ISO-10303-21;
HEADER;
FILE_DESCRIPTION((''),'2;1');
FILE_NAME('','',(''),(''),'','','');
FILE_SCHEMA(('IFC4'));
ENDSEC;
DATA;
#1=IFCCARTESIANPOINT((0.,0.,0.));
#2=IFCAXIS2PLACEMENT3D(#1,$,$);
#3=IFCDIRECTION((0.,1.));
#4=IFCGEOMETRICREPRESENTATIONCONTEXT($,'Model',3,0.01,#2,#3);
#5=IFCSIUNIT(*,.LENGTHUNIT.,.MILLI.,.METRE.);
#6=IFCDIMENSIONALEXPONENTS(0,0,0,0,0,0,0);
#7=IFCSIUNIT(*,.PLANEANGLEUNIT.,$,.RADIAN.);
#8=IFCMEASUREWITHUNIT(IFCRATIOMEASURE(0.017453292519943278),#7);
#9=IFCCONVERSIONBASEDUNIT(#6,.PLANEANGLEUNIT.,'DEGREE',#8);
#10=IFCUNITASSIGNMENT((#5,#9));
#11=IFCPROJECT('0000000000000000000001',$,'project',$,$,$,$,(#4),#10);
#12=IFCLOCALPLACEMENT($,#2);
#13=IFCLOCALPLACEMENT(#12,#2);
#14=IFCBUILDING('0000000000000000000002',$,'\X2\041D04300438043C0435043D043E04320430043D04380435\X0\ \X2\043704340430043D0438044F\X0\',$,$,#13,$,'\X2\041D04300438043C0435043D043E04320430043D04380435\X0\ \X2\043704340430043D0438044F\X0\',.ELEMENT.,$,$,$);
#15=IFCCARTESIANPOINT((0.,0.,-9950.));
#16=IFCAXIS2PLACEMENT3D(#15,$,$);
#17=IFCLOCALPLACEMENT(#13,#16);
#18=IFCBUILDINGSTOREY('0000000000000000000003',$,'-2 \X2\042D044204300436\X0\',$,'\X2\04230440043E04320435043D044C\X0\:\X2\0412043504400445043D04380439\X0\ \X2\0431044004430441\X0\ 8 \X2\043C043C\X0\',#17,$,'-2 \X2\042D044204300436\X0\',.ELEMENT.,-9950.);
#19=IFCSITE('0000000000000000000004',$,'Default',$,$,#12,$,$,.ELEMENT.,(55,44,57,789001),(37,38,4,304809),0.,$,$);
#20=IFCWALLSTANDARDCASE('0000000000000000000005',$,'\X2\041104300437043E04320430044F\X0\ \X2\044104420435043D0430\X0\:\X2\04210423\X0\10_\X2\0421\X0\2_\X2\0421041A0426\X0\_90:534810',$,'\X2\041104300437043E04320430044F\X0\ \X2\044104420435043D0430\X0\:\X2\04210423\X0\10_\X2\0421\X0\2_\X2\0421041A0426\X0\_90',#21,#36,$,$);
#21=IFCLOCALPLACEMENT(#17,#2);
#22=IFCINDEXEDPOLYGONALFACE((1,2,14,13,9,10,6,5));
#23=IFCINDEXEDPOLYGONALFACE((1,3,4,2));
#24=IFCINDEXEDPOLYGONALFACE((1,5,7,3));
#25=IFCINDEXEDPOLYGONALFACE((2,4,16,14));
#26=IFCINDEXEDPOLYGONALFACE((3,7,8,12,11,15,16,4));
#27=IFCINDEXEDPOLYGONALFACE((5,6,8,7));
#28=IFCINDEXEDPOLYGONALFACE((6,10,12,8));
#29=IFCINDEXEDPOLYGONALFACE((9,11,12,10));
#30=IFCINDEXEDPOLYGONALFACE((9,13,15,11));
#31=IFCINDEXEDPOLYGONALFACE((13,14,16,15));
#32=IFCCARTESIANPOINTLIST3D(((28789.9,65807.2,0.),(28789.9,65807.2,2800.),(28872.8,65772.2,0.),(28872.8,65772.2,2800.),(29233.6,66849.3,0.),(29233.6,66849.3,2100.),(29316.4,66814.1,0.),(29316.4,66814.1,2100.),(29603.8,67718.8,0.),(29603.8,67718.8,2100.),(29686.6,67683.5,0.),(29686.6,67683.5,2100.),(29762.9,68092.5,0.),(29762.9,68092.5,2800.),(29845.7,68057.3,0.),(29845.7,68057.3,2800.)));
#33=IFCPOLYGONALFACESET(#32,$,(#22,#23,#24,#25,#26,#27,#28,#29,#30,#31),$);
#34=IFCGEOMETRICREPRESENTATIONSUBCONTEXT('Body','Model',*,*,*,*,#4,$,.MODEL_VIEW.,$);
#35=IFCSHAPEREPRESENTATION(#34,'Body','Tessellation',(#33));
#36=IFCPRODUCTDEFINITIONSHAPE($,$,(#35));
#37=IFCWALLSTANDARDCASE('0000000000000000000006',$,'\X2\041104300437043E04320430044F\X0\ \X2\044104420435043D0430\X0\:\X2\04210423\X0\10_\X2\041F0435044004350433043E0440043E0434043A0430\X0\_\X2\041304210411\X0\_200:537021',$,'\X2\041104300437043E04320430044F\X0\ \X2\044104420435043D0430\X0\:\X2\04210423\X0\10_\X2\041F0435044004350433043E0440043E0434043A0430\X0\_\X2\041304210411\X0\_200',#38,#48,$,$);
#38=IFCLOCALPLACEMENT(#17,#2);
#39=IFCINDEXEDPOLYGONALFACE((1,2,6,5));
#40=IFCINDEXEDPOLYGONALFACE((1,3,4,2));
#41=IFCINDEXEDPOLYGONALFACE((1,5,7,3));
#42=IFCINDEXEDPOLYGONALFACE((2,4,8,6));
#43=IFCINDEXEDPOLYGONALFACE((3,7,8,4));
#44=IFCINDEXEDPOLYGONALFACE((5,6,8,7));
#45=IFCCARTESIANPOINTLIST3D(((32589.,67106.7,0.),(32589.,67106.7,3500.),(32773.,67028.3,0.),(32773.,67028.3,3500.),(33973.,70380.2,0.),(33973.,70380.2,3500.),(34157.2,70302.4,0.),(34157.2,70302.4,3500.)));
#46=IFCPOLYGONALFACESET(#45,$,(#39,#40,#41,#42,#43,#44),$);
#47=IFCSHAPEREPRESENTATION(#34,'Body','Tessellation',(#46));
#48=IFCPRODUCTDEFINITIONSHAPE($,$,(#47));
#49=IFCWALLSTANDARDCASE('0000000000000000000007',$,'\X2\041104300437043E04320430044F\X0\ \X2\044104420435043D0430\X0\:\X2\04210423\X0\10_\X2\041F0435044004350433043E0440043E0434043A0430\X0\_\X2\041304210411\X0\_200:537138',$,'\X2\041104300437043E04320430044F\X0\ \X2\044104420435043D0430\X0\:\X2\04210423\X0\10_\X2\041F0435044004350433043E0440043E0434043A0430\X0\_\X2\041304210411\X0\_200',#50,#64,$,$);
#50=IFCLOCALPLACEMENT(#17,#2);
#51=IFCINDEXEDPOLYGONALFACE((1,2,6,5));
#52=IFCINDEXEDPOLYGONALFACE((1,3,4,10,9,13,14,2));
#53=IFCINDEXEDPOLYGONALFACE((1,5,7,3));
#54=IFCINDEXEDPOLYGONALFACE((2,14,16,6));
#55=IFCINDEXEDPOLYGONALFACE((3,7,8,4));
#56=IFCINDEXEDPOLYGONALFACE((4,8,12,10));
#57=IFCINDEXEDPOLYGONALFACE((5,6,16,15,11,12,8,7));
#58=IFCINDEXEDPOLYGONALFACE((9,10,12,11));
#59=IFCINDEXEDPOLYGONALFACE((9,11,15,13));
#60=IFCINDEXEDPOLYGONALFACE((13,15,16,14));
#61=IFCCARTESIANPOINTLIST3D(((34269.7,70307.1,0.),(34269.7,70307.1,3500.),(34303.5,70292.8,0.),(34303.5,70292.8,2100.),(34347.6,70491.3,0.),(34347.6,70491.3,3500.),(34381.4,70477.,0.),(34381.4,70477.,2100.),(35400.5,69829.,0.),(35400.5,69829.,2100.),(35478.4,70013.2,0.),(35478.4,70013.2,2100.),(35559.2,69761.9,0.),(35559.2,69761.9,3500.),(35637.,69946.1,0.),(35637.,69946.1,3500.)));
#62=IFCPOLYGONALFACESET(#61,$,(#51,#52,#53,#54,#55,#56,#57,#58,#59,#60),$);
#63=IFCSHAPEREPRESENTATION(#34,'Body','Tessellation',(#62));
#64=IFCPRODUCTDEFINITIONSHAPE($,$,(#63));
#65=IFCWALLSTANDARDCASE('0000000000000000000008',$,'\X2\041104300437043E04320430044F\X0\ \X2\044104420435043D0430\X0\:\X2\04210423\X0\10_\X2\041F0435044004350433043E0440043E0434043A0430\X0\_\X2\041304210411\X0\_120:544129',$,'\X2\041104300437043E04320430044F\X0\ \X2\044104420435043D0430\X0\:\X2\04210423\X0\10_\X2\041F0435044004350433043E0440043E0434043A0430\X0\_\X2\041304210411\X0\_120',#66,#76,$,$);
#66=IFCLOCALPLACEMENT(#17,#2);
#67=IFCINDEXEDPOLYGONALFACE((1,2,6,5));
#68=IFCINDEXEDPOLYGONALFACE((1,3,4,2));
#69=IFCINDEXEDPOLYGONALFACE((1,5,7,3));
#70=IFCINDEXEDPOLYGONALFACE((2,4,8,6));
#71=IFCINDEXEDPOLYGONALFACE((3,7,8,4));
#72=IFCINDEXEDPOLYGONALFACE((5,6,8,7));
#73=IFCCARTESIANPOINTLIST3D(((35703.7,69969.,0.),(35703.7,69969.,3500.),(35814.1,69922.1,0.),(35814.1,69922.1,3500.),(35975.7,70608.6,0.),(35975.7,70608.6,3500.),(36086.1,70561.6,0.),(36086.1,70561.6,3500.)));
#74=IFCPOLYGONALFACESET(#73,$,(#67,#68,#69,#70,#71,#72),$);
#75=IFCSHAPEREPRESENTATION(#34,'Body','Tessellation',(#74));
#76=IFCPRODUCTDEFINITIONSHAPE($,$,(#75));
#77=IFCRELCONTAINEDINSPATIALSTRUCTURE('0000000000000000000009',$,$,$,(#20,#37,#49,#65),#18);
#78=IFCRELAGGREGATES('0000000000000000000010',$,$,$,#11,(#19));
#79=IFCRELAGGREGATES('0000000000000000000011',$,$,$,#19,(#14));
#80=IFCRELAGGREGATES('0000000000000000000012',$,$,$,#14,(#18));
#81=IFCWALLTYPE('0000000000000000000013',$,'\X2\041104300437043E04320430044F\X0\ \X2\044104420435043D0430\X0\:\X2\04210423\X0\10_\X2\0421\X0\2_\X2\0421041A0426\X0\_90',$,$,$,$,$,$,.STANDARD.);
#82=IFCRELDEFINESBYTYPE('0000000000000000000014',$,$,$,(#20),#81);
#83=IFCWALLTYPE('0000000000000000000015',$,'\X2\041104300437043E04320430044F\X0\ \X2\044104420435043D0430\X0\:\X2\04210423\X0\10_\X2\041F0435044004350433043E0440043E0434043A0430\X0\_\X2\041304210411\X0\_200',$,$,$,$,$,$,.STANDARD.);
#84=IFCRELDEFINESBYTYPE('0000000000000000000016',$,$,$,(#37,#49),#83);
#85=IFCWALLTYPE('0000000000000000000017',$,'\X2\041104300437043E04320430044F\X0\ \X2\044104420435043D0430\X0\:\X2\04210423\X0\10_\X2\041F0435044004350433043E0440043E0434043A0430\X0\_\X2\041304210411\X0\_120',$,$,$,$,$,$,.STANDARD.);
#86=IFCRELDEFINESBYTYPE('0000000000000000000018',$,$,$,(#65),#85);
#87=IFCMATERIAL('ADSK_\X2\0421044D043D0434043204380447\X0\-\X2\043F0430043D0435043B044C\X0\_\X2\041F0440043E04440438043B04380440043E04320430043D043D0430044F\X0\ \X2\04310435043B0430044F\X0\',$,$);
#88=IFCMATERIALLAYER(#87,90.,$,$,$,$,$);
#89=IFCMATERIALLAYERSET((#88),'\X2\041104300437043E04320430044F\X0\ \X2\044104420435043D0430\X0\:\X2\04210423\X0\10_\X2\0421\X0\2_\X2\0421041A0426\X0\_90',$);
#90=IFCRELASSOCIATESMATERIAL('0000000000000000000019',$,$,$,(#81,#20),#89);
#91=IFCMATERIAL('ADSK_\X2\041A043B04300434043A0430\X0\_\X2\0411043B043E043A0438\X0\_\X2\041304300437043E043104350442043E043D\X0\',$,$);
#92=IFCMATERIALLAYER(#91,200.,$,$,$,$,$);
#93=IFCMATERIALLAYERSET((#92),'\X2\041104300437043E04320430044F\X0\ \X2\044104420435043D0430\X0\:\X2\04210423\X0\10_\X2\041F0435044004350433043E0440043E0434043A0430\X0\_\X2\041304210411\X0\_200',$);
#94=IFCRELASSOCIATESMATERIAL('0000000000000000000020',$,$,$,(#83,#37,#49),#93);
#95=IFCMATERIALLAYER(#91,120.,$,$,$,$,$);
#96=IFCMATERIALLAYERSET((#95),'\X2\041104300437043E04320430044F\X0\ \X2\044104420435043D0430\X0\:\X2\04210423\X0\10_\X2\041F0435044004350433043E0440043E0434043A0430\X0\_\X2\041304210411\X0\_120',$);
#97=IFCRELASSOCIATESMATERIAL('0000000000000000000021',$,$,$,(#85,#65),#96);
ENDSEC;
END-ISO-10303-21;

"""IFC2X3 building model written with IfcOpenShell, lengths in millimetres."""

from ifc_helpers import new_model, entity, si_unit, converted_unit, direction, frame, frame_2d, origin, place, context, subcontext, project, spatial, polyline, rectangle, outline, extrude, material, layer, layer_set, layer_usage, type_object, element, save


model = new_model("IFC2X3")

# Units and contexts
model_context = context("Model", 3, precision=0.01, world=origin(), true_north=direction((0.0, 1.0)))
body_context = subcontext(model_context, "Body", "Model", "MODEL_VIEW")
ifc_project = project(units=[si_unit("LENGTHUNIT", "METRE", prefix="MILLI"), converted_unit("PLANEANGLEUNIT", "DEGREE", entity("IfcRatioMeasure", 0.017453292519943278), si_unit("PLANEANGLEUNIT", "RADIAN"), dimensions=[0, 0, 0, 0, 0, 0, 0])], contexts=[model_context])

# Site, building, storey
site_placement = place(None, origin())
site = spatial("IfcSite", under=ifc_project, at=site_placement, Name="Default", CompositionType="ELEMENT", RefLatitude=(55, 44, 57, 789001), RefLongitude=(37, 38, 4, 304809), RefElevation=0.0)
building_placement = place(site_placement, origin())
building = spatial("IfcBuilding", under=site, at=building_placement, Name="Наименование здания", LongName="Наименование здания", CompositionType="ELEMENT")
storey_placement = place(building_placement, frame((0.0, 0.0, -9950.0)))
storey = spatial("IfcBuildingStorey", under=building, at=storey_placement, Name="-2 Этаж", ObjectType="Уровень:Верхний брус 8 мм", LongName="-2 Этаж", CompositionType="ELEMENT", Elevation=-9950.0)

# Wall, opening
ifc_material_1 = material(Name="ADSK_Сэндвич-панель_Профилированная белая")
ifc_layer_1 = layer(ifc_material_1, 90.0)
ifc_layer_set_1 = layer_set([ifc_layer_1], Name="Базовая стена:СУ10_С2_СКЦ_90")
ifc_layer_usage_1 = layer_usage(ifc_layer_set_1, "AXIS2", "NEGATIVE", 45.0)
wall_type_1 = type_object("IfcWallType", Name="Базовая стена:СУ10_С2_СКЦ_90", PredefinedType="STANDARD", material=ifc_layer_set_1)
wall_1_placement = place(storey_placement, frame((29804.3, 68074.9, 0.0), z_axis=(0.0, 0.0, 1.0), x_axis=(-0.391735, -0.920078, 0.0)))
wall_1 = element("IfcWallStandardCase", 1, at=wall_1_placement, inside=storey, type_object=wall_type_1, material=ifc_layer_usage_1, Name="Базовая стена:СУ10_С2_СКЦ_90:534810", ObjectType="Базовая стена:СУ10_С2_СКЦ_90", context=body_context, shape_type="SweptSolid", body=[
    extrude(outline(polyline([(0.0, -45.0), (2483.8, -45.0), (2483.6, 45.0), (0.0, 45.0), (0.0, -45.0)])), origin(), (0.0, 0.0, 1.0), 2800.0),
])
opening_1_placement = place(wall_1_placement, origin())
element("IfcOpeningElement", 2, at=opening_1_placement, cuts=wall_1, ObjectType="Opening", context=body_context, shape_type="SweptSolid", body=[
    extrude(rectangle(XDim=2100.0, YDim=944.9, at=frame_2d((0.0, 0.0), x_axis=(1.0, 0.0))), frame((878.7, -45.0, 1050.0), z_axis=(0.0, 1.0, 0.0), x_axis=(0.0, 0.0, -1.0)), (0.0, 0.0, 1.0), 90.0),
])

# Wall
ifc_material_2 = material(Name="ADSK_Кладка_Блоки_Газобетон")
ifc_layer_2 = layer(ifc_material_2, 200.0)
ifc_layer_set_2 = layer_set([ifc_layer_2], Name="Базовая стена:СУ10_Перегородка_ГСБ_200")
ifc_layer_usage_2 = layer_usage(ifc_layer_set_2, "AXIS2", "NEGATIVE", 100.0)
wall_type_2 = type_object("IfcWallType", Name="Базовая стена:СУ10_Перегородка_ГСБ_200", PredefinedType="STANDARD", material=ifc_layer_set_2)
wall_2_placement = place(storey_placement, frame((32680.9, 67067.3, 0.0), z_axis=(0.0, 0.0, 1.0), x_axis=(0.389417, 0.921062, 0.0)))
element("IfcWallStandardCase", 3, at=wall_2_placement, inside=storey, type_object=wall_type_2, material=ifc_layer_usage_2, Name="Базовая стена:СУ10_Перегородка_ГСБ_200:537021", ObjectType="Базовая стена:СУ10_Перегородка_ГСБ_200", context=body_context, shape_type="SweptSolid", body=[
    extrude(outline(polyline([(3554.6, -100.0), (3554.6, 100.0), (0.5, 100.0), (0.0, -100.0), (3554.6, -100.0)])), origin(), (0.0, 0.0, 1.0), 3500.0),
])

# Wall, opening
wall_3_placement = place(storey_placement, frame((35598.1, 69854.0, 0.0), z_axis=(0.0, 0.0, 1.0), x_axis=(-0.921062, 0.389417, 0.0)))
wall_3 = element("IfcWallStandardCase", 4, at=wall_3_placement, inside=storey, type_object=wall_type_2, material=ifc_layer_usage_2, Name="Базовая стена:СУ10_Перегородка_ГСБ_200:537138", ObjectType="Базовая стена:СУ10_Перегородка_ГСБ_200", context=body_context, shape_type="SweptSolid", body=[
    extrude(rectangle(XDim=1400.0, YDim=200.0, at=frame_2d((700.0, 0.0), x_axis=(-1.0, 0.0))), origin(), (0.0, 0.0, 1.0), 3500.0),
])
opening_2_placement = place(wall_3_placement, origin())
element("IfcOpeningElement", 5, at=opening_2_placement, cuts=wall_3, ObjectType="Opening", context=body_context, shape_type="SweptSolid", body=[
    extrude(rectangle(XDim=2100.0, YDim=1191.0, at=frame_2d((0.0, 0.0), x_axis=(1.0, 0.0))), frame((767.7, -100.0, 1050.0), z_axis=(0.0, 1.0, 0.0), x_axis=(0.0, 0.0, -1.0)), (0.0, 0.0, 1.0), 200.0),
])

# Wall
ifc_layer_3 = layer(ifc_material_2, 120.0)
ifc_layer_set_3 = layer_set([ifc_layer_3], Name="Базовая стена:СУ10_Перегородка_ГСБ_120")
ifc_layer_usage_3 = layer_usage(ifc_layer_set_3, "AXIS2", "NEGATIVE", 60.0)
wall_type_3 = type_object("IfcWallType", Name="Базовая стена:СУ10_Перегородка_ГСБ_120", PredefinedType="STANDARD", material=ifc_layer_set_3)
wall_4_placement = place(storey_placement, frame((36030.9, 70585.1, 0.0), z_axis=(0.0, 0.0, 1.0), x_axis=(-0.391365, -0.920236, 0.0)))
element("IfcWallStandardCase", 6, at=wall_4_placement, inside=storey, type_object=wall_type_3, material=ifc_layer_usage_3, Name="Базовая стена:СУ10_Перегородка_ГСБ_120:544129", ObjectType="Базовая стена:СУ10_Перегородка_ГСБ_120", context=body_context, shape_type="SweptSolid", body=[
    extrude(rectangle(XDim=695.0, YDim=120.0, at=frame_2d((347.5, 0.0), x_axis=(-1.0, 0.0))), origin(), (0.0, 0.0, 1.0), 3500.0),
])

save(model, "model.ifc")
